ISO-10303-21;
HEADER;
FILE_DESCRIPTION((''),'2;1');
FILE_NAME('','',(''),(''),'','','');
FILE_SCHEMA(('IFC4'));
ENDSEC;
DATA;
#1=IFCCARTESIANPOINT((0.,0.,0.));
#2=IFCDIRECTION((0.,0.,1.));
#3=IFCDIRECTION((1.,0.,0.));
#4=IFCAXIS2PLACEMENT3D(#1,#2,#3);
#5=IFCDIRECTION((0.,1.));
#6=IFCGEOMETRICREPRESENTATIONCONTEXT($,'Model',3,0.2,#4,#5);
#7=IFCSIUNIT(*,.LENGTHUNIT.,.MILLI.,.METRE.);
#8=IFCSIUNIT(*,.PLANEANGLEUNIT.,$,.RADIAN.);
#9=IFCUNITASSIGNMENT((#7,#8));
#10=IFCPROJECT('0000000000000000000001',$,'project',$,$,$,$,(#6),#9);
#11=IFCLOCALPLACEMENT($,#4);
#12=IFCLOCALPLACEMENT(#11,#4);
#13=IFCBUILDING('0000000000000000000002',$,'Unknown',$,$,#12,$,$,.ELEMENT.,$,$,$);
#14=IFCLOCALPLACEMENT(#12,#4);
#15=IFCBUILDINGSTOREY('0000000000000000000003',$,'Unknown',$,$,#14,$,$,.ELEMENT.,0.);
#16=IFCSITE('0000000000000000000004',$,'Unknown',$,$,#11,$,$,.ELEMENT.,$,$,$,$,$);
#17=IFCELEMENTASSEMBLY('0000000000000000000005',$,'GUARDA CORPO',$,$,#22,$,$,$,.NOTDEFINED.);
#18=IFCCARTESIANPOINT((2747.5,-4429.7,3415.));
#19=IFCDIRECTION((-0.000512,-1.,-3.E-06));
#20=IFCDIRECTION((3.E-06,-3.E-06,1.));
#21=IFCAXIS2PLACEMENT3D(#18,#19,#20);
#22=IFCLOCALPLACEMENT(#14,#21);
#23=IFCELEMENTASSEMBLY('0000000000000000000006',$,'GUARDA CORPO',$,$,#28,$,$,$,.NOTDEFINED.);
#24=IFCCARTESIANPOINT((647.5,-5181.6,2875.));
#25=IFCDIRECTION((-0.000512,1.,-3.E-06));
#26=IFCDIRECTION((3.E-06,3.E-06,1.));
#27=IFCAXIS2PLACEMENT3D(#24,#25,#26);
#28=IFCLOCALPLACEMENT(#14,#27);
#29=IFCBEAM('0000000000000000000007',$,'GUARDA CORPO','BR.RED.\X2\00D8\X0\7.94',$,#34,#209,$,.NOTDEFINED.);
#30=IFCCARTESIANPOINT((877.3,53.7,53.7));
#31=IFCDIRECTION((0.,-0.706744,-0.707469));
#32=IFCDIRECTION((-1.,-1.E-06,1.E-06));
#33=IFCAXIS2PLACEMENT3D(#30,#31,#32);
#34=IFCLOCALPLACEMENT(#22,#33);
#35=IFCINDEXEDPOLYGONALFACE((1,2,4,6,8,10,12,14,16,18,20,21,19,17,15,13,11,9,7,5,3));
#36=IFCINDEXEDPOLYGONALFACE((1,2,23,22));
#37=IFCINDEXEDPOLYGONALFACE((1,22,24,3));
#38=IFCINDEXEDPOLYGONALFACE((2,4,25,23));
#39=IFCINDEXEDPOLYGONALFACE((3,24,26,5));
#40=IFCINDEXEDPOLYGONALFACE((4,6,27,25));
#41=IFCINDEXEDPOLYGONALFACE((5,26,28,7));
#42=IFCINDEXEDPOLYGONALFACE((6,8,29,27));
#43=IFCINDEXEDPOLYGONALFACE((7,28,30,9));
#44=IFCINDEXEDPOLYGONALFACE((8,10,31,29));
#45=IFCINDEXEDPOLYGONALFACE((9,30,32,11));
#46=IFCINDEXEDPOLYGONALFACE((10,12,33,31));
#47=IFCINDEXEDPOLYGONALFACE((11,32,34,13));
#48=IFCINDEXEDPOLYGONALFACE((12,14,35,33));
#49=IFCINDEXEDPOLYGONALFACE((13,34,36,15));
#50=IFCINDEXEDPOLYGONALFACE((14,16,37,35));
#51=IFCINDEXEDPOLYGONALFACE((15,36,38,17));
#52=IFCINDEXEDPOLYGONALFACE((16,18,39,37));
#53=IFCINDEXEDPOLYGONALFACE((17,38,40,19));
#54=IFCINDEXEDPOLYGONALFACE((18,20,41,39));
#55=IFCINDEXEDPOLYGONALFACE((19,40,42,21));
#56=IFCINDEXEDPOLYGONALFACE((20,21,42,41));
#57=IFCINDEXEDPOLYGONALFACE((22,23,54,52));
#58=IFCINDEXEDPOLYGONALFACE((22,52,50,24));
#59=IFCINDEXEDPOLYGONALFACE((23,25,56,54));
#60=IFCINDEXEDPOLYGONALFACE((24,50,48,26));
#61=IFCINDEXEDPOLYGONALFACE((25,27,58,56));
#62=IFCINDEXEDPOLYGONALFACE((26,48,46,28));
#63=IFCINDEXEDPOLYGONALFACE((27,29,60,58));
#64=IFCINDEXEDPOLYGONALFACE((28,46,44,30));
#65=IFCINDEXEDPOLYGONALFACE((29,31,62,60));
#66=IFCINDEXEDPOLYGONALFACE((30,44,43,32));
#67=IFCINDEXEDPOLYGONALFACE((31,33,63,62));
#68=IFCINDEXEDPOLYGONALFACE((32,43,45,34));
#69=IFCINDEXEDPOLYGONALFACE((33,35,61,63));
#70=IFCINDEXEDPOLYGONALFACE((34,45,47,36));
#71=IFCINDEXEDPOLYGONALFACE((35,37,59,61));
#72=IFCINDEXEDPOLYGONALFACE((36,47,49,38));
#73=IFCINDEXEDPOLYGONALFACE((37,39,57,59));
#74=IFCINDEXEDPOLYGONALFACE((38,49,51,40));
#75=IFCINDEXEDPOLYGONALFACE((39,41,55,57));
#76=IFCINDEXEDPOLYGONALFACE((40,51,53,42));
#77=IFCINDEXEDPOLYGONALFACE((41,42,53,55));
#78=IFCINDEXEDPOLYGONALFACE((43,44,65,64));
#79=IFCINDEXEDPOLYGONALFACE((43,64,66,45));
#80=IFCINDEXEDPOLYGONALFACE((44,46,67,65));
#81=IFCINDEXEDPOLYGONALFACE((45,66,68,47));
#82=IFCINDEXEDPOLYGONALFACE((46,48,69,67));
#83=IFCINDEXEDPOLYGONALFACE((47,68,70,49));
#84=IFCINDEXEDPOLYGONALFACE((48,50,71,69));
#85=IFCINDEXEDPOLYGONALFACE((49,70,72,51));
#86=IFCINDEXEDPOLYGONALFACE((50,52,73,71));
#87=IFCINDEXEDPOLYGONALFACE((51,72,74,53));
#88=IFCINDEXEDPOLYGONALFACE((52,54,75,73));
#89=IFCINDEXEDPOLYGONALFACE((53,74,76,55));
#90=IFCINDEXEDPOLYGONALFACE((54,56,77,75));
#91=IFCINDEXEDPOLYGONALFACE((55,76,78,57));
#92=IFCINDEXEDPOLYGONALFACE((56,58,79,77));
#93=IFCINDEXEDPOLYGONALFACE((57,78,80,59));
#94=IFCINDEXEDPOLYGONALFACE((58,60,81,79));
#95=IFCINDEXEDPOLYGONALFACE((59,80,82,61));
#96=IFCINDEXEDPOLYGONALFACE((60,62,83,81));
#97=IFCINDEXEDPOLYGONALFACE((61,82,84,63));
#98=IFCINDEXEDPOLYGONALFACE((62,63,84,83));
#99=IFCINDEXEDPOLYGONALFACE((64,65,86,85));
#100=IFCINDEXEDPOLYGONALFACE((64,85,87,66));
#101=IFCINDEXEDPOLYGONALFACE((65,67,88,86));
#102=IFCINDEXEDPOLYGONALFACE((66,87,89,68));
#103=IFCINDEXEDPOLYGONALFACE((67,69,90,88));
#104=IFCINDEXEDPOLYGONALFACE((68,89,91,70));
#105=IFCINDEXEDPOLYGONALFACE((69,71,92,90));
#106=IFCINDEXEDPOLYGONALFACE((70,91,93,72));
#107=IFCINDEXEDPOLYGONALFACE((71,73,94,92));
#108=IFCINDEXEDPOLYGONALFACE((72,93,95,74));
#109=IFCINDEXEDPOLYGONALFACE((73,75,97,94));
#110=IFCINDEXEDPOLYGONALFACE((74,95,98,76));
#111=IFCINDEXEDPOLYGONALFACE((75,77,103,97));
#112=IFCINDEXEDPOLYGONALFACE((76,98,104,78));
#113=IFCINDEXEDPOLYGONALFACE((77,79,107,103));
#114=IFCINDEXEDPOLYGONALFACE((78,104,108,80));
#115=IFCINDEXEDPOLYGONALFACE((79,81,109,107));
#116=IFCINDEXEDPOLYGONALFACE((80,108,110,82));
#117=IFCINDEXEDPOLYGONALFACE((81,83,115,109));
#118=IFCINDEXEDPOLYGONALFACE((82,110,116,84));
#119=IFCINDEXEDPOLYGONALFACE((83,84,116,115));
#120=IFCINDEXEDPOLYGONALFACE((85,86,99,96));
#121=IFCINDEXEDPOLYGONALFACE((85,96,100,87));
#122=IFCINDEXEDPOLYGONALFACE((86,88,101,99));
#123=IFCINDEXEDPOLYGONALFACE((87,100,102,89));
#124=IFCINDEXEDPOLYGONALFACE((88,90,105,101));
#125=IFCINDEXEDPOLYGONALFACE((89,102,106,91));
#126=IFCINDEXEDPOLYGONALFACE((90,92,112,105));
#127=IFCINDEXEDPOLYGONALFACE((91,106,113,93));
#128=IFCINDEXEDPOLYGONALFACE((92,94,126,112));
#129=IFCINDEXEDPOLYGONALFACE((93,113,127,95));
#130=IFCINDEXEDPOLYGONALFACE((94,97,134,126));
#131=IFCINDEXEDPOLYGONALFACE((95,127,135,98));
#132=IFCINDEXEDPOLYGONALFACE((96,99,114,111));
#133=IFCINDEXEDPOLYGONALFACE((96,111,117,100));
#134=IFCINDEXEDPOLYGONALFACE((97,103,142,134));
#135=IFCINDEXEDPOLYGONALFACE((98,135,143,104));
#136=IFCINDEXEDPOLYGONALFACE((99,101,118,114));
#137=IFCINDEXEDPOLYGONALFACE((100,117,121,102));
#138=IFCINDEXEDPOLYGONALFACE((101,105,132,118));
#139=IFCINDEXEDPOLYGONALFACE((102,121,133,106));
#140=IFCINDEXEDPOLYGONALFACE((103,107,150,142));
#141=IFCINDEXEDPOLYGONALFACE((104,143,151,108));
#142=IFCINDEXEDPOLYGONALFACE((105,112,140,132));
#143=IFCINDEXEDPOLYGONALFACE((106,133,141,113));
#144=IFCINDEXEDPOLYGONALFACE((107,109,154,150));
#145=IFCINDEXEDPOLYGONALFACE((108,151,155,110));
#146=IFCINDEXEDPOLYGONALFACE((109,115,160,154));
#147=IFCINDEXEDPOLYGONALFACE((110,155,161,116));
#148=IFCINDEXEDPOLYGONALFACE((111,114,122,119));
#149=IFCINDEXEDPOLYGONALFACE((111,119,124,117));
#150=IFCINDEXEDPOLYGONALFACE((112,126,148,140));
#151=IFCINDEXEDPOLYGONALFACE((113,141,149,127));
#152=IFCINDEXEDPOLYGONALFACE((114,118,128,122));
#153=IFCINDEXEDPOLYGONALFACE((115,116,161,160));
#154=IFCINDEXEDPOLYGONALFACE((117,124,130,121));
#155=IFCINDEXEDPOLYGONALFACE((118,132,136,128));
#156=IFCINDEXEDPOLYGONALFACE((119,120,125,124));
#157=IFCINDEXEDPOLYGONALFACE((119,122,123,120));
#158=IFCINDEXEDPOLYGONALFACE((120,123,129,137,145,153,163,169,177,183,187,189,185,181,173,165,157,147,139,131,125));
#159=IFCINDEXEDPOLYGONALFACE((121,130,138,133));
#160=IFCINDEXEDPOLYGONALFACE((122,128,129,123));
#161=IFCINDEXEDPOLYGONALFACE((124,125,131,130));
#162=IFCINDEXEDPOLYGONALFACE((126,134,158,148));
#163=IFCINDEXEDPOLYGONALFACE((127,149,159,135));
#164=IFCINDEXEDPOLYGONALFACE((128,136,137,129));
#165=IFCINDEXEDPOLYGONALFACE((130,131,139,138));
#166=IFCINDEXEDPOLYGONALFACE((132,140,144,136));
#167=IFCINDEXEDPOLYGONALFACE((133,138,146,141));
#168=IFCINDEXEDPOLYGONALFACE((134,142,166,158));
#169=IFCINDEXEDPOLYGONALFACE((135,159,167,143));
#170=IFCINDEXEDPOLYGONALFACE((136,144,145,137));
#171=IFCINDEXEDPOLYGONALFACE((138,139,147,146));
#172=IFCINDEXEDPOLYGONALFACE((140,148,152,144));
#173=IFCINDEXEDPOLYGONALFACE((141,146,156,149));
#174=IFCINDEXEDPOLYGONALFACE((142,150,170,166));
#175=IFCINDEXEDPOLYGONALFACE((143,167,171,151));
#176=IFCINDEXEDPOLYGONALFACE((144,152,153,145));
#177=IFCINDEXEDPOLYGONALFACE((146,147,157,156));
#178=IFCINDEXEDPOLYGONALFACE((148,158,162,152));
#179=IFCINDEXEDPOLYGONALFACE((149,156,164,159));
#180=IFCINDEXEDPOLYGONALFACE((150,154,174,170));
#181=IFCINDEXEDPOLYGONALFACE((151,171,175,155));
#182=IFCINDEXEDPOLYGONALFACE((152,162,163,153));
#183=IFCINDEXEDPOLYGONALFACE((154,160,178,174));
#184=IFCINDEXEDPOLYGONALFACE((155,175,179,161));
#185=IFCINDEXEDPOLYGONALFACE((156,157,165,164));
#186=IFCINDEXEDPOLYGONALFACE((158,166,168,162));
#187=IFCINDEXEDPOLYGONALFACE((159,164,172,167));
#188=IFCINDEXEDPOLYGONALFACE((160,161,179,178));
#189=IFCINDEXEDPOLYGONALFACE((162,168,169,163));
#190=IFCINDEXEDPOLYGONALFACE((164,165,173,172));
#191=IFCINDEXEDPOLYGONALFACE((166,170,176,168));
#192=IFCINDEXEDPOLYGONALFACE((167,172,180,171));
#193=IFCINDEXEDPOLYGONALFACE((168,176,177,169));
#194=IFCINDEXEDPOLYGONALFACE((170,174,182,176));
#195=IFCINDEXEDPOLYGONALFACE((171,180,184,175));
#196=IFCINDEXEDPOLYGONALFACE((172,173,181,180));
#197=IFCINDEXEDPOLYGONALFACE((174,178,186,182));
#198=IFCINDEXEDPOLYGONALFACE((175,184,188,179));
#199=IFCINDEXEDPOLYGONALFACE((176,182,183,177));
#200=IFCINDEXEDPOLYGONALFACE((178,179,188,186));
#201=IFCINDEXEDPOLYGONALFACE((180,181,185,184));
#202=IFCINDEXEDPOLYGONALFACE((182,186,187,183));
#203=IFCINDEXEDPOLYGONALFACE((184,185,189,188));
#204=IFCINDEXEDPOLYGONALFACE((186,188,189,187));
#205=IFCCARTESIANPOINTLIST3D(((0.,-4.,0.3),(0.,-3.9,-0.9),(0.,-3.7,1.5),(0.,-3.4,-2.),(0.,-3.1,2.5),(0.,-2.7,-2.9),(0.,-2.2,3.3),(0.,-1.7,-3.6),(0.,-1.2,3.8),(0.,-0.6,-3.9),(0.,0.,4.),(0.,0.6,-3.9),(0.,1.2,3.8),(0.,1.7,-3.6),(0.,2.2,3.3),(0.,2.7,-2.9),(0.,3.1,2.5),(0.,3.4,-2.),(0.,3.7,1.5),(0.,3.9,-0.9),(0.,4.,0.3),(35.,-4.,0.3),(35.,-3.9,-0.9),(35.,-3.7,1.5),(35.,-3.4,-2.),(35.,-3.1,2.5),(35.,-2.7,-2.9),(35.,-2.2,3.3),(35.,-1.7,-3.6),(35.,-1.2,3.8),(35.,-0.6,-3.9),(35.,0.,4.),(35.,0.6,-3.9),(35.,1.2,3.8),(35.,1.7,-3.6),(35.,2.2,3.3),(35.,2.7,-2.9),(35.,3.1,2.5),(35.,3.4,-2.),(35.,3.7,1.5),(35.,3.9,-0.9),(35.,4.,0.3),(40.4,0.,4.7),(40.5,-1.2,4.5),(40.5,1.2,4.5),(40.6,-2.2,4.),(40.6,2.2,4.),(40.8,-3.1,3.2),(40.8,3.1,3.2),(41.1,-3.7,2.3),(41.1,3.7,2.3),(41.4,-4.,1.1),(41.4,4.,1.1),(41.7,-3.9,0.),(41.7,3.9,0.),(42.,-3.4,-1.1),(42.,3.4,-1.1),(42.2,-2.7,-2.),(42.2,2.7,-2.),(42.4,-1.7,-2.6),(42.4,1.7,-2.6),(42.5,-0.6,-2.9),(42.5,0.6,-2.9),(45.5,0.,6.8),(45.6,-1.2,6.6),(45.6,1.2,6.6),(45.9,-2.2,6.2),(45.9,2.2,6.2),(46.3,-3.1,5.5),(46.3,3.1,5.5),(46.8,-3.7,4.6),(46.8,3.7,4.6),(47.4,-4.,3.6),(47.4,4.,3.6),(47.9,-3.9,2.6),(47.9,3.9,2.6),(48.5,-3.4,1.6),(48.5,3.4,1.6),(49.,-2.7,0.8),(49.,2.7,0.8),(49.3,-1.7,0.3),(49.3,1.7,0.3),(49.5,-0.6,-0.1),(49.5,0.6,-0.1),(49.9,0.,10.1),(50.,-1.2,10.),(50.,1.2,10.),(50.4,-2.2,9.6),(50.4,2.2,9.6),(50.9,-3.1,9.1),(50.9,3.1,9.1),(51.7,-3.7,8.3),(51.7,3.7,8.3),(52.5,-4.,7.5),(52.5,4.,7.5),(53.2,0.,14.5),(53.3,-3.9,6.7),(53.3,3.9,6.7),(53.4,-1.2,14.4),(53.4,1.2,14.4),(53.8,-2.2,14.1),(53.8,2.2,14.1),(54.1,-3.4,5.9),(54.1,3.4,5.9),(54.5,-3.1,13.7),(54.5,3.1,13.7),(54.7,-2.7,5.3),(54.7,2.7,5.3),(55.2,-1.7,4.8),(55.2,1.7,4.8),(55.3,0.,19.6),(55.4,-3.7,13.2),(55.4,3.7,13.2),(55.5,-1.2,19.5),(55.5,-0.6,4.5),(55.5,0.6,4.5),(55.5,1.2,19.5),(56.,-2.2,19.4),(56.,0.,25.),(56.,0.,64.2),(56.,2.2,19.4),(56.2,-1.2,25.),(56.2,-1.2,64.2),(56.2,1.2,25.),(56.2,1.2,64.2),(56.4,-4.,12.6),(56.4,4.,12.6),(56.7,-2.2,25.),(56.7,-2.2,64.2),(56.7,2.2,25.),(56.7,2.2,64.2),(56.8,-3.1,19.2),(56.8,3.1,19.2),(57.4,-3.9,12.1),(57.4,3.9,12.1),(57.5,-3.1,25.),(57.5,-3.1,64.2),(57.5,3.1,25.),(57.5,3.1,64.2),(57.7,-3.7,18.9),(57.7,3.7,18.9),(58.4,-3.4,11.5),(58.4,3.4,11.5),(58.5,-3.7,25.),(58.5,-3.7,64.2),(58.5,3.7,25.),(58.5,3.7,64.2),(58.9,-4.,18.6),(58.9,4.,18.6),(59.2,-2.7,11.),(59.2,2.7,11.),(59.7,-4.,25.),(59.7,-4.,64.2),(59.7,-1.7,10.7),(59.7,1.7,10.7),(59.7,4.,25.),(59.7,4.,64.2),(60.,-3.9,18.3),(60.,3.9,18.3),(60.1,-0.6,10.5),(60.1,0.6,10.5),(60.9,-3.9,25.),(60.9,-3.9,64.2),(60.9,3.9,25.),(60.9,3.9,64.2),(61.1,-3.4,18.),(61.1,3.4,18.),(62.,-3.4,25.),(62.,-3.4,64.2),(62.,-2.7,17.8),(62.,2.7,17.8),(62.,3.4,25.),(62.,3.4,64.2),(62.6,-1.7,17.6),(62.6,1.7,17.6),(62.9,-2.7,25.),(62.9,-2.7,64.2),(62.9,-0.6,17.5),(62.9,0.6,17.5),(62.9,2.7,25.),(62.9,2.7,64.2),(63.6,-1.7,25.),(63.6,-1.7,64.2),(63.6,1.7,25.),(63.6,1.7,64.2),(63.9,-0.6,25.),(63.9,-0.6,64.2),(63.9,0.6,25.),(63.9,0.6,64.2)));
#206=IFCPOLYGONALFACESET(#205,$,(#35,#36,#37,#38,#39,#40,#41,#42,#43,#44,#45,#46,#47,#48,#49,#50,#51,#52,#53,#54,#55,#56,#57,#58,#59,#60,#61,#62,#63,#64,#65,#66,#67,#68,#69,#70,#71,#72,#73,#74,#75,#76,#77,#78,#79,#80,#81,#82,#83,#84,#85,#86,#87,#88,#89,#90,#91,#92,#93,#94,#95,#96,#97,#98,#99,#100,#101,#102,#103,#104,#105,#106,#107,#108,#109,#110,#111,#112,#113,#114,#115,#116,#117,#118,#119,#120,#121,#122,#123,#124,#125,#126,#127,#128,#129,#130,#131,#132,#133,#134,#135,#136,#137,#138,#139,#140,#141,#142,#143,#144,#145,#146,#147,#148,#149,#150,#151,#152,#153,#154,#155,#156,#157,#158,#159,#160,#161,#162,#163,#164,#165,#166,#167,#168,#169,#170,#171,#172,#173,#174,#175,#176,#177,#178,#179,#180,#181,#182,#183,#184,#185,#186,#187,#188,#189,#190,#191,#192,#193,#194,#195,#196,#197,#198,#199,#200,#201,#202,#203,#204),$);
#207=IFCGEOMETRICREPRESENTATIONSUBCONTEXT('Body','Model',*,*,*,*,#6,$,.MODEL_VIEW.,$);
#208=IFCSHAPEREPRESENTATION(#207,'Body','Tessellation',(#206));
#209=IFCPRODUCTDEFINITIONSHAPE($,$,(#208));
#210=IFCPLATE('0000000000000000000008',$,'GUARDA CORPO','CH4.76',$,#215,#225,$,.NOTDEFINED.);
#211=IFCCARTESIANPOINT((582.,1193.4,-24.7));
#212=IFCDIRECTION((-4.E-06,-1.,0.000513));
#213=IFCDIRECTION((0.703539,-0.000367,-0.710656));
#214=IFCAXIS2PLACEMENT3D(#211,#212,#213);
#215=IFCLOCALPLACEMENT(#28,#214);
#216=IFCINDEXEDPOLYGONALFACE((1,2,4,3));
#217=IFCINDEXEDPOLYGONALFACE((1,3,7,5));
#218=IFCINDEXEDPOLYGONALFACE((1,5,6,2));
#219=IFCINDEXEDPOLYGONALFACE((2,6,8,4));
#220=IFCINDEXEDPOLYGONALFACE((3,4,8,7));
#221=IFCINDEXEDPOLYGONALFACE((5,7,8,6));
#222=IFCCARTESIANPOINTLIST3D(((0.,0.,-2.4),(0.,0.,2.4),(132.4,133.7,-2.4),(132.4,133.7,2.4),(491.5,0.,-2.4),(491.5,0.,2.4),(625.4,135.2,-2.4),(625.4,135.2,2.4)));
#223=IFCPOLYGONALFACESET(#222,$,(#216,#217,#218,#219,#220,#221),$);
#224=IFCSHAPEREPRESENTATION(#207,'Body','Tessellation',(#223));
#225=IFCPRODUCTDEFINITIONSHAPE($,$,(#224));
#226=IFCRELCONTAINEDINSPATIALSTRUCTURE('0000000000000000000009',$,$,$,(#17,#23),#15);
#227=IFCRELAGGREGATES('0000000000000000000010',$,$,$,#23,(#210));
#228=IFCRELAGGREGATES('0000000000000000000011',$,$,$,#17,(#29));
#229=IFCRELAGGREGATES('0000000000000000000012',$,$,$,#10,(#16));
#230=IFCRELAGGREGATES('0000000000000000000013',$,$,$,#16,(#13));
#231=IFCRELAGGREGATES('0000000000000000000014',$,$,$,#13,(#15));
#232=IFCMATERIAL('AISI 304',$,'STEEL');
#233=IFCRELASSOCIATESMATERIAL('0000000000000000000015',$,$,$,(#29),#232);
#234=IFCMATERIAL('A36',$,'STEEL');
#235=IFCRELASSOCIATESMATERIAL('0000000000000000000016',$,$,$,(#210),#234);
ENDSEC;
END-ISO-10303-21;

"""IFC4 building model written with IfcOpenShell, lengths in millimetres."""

from ifc_helpers import new_model, entity, si_unit, direction, frame, origin_with_axes, place, context, subcontext, project, spatial, line, indexed_curve, outline, extrude, material, element, aggregate, save


model = new_model("IFC4")

# Units and contexts
model_context = context("Model", 3, precision=0.2, world=origin_with_axes(), true_north=direction((0.0, 1.0)))
body_context = subcontext(model_context, "Body", "Model", "MODEL_VIEW")
ifc_project = project(units=[si_unit("LENGTHUNIT", "METRE", prefix="MILLI"), si_unit("PLANEANGLEUNIT", "RADIAN")], contexts=[model_context])

# Site, building, storey
site_placement = place(None, origin_with_axes())
site = spatial("IfcSite", under=ifc_project, at=site_placement, Name="Unknown", CompositionType="ELEMENT")
building_placement = place(site_placement, origin_with_axes())
building = spatial("IfcBuilding", under=site, at=building_placement, Name="Unknown", CompositionType="ELEMENT")
storey_placement = place(building_placement, origin_with_axes())
storey = spatial("IfcBuildingStorey", under=building, at=storey_placement, Name="Unknown", CompositionType="ELEMENT", Elevation=0.0)

# Element assembly
assembly_1_placement = place(storey_placement, frame((2747.5, -4429.7, 3415.0), z_axis=(-0.000512, -1.0, -0.000003), x_axis=(0.000003, -0.000003, 1.0)))
assembly_1 = element("IfcElementAssembly", 1, at=assembly_1_placement, inside=storey, Name="GUARDA CORPO", PredefinedType="NOTDEFINED")
ifc_material_1 = material(Name="AISI 304", Category="STEEL")

# Shared definitions
ifc_material_2 = material(Name="A36", Category="STEEL")

# Element assembly
assembly_2_placement = place(storey_placement, frame((647.5, -5181.6, 2875.0), z_axis=(-0.000512, 1.0, -0.000003), x_axis=(0.000003, 0.000003, 1.0)))
assembly_2 = element("IfcElementAssembly", 2, at=assembly_2_placement, inside=storey, Name="GUARDA CORPO", PredefinedType="NOTDEFINED")

# Beam
beam_1_placement = place(assembly_1_placement, frame((877.3, 53.7, 53.7), z_axis=(0.0, -0.706744, -0.707469), x_axis=(-1.0, -0.000001, 0.000001)))
beam_1 = element("IfcBeam", 3, at=beam_1_placement, material=ifc_material_1, Name="GUARDA CORPO", Description="BR.RED.Ø7.94", PredefinedType="NOTDEFINED", context=body_context, shape_type="SolidModel", body=[
    entity("IfcSweptDiskSolid", entity("IfcIndexedPolyCurve", entity("IfcCartesianPointList3D", [[0.0, 0.0, 0.0], [35.0, 0.0, 0.0], [52.7, 0.0, 7.3], [60.0, 0.0, 25.0], [60.0, 0.0, 64.2]]), [entity("IfcLineIndex", [1, 2]), entity("IfcArcIndex", [2, 3, 4]), entity("IfcLineIndex", [4, 5])]), 4.0),
])

# Plate
plate_1_placement = place(assembly_2_placement, frame((582.0, 1193.4, -24.7), z_axis=(-0.000004, -1.0, 0.000513), x_axis=(0.703539, -0.000367, -0.710656)))
plate_1 = element("IfcPlate", 4, at=plate_1_placement, material=ifc_material_2, Name="GUARDA CORPO", Description="CH4.76", PredefinedType="NOTDEFINED", context=body_context, shape_type="SolidModel", body=[
    extrude(outline(indexed_curve([(0.0, 0.0), (491.5, 0.0), (625.4, 135.2), (132.4, 133.7)], segments=[line(1, 2, 3, 4, 1)])), frame((0.0, 0.0, 2.4), z_axis=(0.0, 0.0, 1.0), x_axis=(1.0, 0.0, 0.0)), (0.0, 0.0, -1.0), 4.8),
])
aggregate(assembly_2, [plate_1])

aggregate(assembly_1, [beam_1])

save(model, "model.ifc")
